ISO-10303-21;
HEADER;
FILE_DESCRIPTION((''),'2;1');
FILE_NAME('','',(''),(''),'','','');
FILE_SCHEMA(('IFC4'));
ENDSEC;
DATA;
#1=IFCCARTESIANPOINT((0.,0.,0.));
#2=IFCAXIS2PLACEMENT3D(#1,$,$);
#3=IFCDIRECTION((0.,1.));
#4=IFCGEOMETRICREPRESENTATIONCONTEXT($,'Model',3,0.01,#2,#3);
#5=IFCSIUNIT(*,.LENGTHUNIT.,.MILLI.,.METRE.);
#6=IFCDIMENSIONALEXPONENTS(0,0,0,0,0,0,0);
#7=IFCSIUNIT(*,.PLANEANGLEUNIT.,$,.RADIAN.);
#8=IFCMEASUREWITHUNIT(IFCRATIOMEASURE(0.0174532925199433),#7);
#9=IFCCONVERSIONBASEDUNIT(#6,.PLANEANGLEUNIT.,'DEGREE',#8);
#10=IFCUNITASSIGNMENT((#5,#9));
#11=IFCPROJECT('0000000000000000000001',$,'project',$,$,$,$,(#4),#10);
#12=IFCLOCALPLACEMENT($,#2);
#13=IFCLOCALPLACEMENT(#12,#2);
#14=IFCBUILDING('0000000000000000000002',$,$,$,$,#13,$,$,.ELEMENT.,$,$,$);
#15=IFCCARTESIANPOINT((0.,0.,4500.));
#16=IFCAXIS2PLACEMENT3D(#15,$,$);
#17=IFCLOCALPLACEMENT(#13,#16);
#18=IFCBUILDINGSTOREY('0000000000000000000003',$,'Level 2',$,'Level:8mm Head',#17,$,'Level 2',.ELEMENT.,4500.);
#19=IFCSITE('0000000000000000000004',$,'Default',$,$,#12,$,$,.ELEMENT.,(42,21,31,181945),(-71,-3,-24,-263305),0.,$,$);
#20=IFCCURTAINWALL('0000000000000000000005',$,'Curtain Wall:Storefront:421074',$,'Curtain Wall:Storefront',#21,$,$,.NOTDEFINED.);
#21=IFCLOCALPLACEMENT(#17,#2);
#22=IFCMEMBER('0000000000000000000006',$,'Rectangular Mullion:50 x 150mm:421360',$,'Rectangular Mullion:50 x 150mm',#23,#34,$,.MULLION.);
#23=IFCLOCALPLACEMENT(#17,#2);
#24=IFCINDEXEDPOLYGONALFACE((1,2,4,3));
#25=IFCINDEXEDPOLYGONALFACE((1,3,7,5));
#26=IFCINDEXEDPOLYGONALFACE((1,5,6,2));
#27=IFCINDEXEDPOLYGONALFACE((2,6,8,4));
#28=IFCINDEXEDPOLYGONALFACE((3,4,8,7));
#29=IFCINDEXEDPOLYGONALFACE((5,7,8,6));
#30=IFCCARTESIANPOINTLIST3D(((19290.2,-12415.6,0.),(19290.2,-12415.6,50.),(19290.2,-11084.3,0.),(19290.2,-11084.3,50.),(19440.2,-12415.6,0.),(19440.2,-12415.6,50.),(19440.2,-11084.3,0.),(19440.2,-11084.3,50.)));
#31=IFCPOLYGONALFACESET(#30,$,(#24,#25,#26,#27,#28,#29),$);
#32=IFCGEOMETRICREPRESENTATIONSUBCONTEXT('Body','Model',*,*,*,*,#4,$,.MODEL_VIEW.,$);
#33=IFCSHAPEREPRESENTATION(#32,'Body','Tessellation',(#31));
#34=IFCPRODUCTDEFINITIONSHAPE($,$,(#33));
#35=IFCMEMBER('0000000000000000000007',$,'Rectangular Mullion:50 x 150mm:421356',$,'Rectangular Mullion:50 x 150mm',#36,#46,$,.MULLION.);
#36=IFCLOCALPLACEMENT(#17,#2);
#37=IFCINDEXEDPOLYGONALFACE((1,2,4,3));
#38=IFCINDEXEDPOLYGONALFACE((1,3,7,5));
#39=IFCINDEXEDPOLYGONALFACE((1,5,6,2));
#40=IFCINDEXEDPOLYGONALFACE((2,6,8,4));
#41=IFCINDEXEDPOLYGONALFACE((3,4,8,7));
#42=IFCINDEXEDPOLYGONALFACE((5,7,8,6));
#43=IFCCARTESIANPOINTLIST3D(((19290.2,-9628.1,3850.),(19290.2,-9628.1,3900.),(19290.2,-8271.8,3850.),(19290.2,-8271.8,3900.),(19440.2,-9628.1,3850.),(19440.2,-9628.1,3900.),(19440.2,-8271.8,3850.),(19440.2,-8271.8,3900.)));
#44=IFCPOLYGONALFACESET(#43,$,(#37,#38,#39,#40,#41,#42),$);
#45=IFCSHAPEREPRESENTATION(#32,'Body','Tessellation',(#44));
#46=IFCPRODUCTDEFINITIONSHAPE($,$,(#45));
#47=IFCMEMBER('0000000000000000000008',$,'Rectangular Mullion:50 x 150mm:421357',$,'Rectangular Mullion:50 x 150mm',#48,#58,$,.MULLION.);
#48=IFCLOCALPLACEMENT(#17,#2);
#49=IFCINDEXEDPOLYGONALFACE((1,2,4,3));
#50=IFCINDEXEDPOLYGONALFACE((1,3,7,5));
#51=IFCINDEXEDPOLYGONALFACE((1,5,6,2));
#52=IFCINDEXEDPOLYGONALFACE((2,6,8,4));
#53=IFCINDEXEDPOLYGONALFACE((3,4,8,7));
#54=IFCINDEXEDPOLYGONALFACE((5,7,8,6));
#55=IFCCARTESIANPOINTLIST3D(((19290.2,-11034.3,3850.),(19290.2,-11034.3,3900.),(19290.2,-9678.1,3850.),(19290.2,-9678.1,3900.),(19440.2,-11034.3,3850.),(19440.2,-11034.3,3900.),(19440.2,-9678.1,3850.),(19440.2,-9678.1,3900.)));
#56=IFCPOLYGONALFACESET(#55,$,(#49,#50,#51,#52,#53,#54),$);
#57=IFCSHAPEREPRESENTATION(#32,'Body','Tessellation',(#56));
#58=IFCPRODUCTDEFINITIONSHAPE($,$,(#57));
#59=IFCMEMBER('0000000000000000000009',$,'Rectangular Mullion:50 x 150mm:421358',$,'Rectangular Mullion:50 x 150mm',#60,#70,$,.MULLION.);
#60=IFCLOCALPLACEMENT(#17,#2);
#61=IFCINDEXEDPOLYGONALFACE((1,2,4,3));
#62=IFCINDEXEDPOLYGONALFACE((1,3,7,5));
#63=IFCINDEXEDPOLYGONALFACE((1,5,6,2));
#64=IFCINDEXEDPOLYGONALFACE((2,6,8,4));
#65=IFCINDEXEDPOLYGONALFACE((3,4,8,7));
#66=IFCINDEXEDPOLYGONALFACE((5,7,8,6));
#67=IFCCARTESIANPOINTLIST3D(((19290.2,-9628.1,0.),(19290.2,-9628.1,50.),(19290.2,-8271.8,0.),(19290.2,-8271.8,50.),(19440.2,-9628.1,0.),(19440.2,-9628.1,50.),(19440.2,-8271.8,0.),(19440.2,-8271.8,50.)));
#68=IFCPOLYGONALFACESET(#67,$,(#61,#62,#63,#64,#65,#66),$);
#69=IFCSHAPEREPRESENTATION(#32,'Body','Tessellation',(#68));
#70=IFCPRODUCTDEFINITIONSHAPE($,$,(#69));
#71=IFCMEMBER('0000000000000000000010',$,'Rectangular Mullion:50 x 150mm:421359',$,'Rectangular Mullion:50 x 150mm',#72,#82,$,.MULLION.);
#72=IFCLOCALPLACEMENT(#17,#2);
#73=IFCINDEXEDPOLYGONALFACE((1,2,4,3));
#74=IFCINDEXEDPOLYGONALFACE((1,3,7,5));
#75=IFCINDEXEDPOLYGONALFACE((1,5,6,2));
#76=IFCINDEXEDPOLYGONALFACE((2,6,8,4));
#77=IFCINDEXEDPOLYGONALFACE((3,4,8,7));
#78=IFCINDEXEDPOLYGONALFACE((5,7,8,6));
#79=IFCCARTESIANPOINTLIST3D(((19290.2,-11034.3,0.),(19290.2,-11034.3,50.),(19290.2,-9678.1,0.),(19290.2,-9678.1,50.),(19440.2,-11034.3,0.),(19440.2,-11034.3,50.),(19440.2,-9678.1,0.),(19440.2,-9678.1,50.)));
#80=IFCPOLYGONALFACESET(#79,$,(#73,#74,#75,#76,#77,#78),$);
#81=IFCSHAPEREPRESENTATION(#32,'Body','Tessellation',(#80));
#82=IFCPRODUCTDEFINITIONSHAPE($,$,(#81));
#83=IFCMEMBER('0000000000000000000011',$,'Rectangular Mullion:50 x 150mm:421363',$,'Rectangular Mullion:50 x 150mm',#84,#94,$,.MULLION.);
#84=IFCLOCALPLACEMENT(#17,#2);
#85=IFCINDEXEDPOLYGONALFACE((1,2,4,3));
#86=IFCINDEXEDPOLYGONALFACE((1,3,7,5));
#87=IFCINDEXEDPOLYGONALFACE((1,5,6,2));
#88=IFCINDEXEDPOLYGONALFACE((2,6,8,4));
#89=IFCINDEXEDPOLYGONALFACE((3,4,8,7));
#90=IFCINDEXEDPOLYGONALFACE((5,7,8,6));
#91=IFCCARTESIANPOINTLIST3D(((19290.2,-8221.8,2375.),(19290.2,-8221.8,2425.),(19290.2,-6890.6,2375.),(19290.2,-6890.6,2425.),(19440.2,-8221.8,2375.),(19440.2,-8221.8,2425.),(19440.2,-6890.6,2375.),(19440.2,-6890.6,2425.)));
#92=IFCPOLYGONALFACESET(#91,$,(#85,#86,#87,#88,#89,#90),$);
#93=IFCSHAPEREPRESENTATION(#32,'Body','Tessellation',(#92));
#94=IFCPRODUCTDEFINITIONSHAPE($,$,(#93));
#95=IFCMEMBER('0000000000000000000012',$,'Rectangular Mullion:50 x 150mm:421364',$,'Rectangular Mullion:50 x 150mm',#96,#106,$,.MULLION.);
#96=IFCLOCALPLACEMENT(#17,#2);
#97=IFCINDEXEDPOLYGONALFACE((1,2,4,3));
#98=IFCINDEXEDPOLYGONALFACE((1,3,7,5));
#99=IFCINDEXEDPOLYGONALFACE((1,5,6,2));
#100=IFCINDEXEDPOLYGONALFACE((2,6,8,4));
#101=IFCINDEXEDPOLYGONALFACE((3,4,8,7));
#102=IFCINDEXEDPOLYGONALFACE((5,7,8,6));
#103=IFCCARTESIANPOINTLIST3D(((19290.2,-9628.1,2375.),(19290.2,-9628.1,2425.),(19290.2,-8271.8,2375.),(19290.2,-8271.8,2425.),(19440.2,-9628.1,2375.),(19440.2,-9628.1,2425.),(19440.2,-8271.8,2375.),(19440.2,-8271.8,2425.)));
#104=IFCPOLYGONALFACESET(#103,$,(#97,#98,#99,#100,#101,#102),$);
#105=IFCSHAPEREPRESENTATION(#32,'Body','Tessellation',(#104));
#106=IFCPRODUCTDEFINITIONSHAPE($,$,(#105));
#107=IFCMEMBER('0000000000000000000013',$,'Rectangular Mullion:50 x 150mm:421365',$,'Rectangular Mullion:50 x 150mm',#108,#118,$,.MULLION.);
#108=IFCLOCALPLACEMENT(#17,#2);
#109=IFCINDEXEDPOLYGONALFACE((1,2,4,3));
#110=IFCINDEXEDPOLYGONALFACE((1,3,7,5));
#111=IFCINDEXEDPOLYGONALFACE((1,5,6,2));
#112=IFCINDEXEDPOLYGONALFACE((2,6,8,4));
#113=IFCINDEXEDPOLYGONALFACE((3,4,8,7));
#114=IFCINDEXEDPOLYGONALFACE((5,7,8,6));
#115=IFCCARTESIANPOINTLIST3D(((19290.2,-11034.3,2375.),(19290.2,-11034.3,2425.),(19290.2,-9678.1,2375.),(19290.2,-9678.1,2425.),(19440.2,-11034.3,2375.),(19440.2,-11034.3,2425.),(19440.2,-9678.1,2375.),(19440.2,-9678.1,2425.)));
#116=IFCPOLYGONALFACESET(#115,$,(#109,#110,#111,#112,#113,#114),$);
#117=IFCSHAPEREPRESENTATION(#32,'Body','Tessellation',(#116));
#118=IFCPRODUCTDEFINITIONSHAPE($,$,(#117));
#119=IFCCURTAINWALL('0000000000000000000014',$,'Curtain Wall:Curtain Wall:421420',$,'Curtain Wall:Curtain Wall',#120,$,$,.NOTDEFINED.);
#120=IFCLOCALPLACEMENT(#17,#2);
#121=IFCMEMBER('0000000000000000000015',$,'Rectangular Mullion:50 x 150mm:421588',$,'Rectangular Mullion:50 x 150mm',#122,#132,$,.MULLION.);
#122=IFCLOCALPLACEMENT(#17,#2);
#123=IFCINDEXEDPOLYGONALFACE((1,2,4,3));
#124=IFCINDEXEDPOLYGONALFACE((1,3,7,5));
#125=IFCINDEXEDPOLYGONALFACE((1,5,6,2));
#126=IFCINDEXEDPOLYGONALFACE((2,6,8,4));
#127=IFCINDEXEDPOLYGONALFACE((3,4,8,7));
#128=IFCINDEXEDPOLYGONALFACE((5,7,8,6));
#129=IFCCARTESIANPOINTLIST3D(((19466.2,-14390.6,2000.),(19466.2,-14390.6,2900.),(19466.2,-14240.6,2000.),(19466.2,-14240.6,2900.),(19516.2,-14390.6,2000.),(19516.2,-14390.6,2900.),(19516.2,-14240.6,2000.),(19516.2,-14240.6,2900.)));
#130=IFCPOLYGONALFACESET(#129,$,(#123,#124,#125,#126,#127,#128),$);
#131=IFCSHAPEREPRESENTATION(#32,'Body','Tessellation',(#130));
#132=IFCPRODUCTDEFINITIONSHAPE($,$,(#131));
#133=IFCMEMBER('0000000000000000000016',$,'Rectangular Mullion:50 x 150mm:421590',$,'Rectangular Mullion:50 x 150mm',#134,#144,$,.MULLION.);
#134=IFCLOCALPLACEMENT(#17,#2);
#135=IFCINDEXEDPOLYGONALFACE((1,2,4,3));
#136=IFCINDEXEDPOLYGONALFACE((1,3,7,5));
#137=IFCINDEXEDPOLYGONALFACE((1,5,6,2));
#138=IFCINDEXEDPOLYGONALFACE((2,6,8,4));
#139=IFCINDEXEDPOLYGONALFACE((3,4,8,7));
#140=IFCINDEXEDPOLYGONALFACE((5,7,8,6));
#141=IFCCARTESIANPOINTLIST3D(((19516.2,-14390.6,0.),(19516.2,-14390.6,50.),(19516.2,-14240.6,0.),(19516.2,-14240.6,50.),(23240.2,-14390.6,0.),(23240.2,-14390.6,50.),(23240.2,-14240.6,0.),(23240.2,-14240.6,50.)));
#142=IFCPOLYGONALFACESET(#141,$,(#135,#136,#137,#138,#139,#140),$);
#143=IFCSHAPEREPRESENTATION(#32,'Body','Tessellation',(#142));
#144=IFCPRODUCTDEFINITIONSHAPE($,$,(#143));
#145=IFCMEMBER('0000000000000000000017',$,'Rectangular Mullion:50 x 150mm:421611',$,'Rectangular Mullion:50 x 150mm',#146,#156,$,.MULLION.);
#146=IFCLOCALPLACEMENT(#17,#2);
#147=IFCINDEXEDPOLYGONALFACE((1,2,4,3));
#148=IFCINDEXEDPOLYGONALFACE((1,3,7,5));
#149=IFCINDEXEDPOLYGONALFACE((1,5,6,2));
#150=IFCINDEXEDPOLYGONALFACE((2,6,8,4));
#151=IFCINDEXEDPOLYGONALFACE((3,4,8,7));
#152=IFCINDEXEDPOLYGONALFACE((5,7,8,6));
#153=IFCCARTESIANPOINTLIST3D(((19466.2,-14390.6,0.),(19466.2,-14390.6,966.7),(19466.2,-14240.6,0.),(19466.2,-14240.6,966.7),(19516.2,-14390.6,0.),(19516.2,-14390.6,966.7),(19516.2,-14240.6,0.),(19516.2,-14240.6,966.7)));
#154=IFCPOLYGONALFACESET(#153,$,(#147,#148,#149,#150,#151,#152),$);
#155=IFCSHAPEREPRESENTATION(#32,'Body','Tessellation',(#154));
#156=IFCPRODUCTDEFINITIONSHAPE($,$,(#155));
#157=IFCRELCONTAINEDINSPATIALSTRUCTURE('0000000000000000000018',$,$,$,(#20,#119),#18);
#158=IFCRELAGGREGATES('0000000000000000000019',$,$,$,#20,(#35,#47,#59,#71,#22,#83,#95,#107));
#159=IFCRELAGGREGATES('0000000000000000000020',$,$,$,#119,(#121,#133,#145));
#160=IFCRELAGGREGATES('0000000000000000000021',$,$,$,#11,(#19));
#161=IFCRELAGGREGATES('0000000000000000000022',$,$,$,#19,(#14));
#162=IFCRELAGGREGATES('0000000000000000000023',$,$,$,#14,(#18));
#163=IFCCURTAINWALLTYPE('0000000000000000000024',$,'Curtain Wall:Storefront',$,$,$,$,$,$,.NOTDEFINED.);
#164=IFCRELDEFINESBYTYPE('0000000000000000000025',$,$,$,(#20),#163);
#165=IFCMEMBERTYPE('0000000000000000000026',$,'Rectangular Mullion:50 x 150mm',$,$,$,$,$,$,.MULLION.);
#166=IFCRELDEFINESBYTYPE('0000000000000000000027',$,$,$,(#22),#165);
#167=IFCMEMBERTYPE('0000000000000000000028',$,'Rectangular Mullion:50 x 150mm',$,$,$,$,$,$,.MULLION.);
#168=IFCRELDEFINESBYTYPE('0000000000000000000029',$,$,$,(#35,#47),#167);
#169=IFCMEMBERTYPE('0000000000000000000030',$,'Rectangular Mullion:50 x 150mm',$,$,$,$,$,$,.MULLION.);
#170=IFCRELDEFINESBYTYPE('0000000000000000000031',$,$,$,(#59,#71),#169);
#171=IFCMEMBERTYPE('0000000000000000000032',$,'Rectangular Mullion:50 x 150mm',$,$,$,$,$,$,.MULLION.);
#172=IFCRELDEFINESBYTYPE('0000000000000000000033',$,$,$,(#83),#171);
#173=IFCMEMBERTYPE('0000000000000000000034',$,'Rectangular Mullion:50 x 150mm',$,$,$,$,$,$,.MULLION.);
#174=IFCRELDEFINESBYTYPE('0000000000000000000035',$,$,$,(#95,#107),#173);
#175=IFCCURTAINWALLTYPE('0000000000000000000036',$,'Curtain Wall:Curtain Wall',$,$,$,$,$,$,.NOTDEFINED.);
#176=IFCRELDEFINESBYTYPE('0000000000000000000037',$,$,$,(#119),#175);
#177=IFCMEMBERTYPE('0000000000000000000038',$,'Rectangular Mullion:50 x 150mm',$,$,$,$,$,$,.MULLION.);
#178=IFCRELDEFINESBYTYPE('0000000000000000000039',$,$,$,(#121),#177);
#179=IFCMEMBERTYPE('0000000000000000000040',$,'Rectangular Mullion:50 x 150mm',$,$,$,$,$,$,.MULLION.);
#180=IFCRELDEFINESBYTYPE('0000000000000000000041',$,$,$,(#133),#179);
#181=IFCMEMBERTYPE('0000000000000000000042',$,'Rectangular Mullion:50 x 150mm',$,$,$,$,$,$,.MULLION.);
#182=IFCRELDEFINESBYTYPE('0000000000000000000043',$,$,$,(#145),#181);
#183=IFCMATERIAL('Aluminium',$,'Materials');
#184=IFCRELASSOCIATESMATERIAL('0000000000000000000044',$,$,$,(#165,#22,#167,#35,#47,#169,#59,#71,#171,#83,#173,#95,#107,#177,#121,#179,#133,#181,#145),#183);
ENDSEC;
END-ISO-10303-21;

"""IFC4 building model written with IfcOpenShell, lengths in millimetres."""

from ifc_helpers import new_model, entity, si_unit, converted_unit, direction, frame, origin, place, context, subcontext, project, spatial, indexed_curve, outline, extrude, source, transform, mapped, material, type_object, type_shapes, element, aggregate, save


model = new_model("IFC4")

# Units and contexts
model_context = context("Model", 3, precision=0.01, world=origin(), true_north=direction((0.0, 1.0)))
body_context = subcontext(model_context, "Body", "Model", "MODEL_VIEW")
ifc_project = project(units=[si_unit("LENGTHUNIT", "METRE", prefix="MILLI"), converted_unit("PLANEANGLEUNIT", "DEGREE", entity("IfcRatioMeasure", 0.0174532925199433), si_unit("PLANEANGLEUNIT", "RADIAN"), dimensions=[0, 0, 0, 0, 0, 0, 0])], contexts=[model_context])

# Site, building, storey
site_placement = place(None, origin())
site = spatial("IfcSite", under=ifc_project, at=site_placement, Name="Default", CompositionType="ELEMENT", RefLatitude=(42, 21, 31, 181945), RefLongitude=(-71, -3, -24, -263305), RefElevation=0.0)
building_placement = place(site_placement, origin())
building = spatial("IfcBuilding", under=site, at=building_placement, CompositionType="ELEMENT")
storey_placement = place(building_placement, frame((0.0, 0.0, 4500.0)))
storey = spatial("IfcBuildingStorey", under=building, at=storey_placement, Name="Level 2", ObjectType="Level:8mm Head", LongName="Level 2", CompositionType="ELEMENT", Elevation=4500.0)

# Curtain wall
curtain_wall_type_1 = type_object("IfcCurtainWallType", Name="Curtain Wall:Storefront", PredefinedType="NOTDEFINED")
curtain_wall_1_placement = place(storey_placement, frame((0.0, 0.0, -4500.0)))
curtain_wall_1 = element("IfcCurtainWall", 1, at=curtain_wall_1_placement, inside=storey, type_object=curtain_wall_type_1, Name="Curtain Wall:Storefront:421074", ObjectType="Curtain Wall:Storefront", PredefinedType="NOTDEFINED")
ifc_material_1 = material(Name="Aluminium", Category="Materials")

# Members
member_type_1 = type_object("IfcMemberType", Name="Rectangular Mullion:50 x 150mm", PredefinedType="MULLION", material=ifc_material_1)
shared_shape_1 = source(origin(), body_context, "Body", "SweptSolid", [
    extrude(outline(indexed_curve([(-75.0, -25.0), (75.0, -25.0), (75.0, 25.0), (-75.0, 25.0), (-75.0, -25.0)], self_intersect=False)), frame((-25.0, 0.0, -1331.3), z_axis=(0.0, 0.0, 1.0), x_axis=(0.0, -1.0, 0.0)), (0.0, 0.0, 1.0), 1331.3),
])
type_shapes(member_type_1, [shared_shape_1])
member_1_placement = place(storey_placement, frame((19365.2, -11084.3, 0.0), z_axis=(0.0, 1.0, 0.0), x_axis=(0.0, 0.0, -1.0)))
member_1 = element("IfcMember", 2, at=member_1_placement, type_object=member_type_1, material=ifc_material_1, Name="Rectangular Mullion:50 x 150mm:421360", ObjectType="Rectangular Mullion:50 x 150mm", PredefinedType="MULLION", context=body_context, shape_type="MappedRepresentation", body=[
    mapped(shared_shape_1, transform((0.0, 0.0, 0.0), scale=1.0)),
])
member_type_2 = type_object("IfcMemberType", Name="Rectangular Mullion:50 x 150mm", PredefinedType="MULLION", material=ifc_material_1)
shared_shape_2 = source(origin(), body_context, "Body", "SweptSolid", [
    extrude(outline(indexed_curve([(-75.0, -25.0), (75.0, -25.0), (75.0, 25.0), (-75.0, 25.0), (-75.0, -25.0)], self_intersect=False)), frame((-25.0, 0.0, -1356.2), z_axis=(0.0, 0.0, 1.0), x_axis=(0.0, -1.0, 0.0)), (0.0, 0.0, 1.0), 1356.2),
])
type_shapes(member_type_2, [shared_shape_2])
member_2_placement = place(storey_placement, frame((19365.2, -9628.1, 3900.0), z_axis=(0.0, -1.0, 0.0), x_axis=(0.0, 0.0, 1.0)))
member_2 = element("IfcMember", 3, at=member_2_placement, type_object=member_type_2, material=ifc_material_1, Name="Rectangular Mullion:50 x 150mm:421356", ObjectType="Rectangular Mullion:50 x 150mm", PredefinedType="MULLION", context=body_context, shape_type="MappedRepresentation", body=[
    mapped(shared_shape_2, transform((0.0, 0.0, 0.0), scale=1.0)),
])
member_3_placement = place(storey_placement, frame((19365.2, -11034.3, 3900.0), z_axis=(0.0, -1.0, 0.0), x_axis=(0.0, 0.0, 1.0)))
member_3 = element("IfcMember", 4, at=member_3_placement, type_object=member_type_2, material=ifc_material_1, Name="Rectangular Mullion:50 x 150mm:421357", ObjectType="Rectangular Mullion:50 x 150mm", PredefinedType="MULLION", context=body_context, shape_type="MappedRepresentation", body=[
    mapped(shared_shape_2, transform((0.0, 0.0, 0.0), scale=1.0)),
])
member_type_3 = type_object("IfcMemberType", Name="Rectangular Mullion:50 x 150mm", PredefinedType="MULLION", material=ifc_material_1)
shared_shape_3 = source(origin(), body_context, "Body", "SweptSolid", [
    extrude(outline(indexed_curve([(-75.0, -25.0), (75.0, -25.0), (75.0, 25.0), (-75.0, 25.0), (-75.0, -25.0)], self_intersect=False)), frame((-25.0, 0.0, -1356.2), z_axis=(0.0, 0.0, 1.0), x_axis=(0.0, -1.0, 0.0)), (0.0, 0.0, 1.0), 1356.2),
])
type_shapes(member_type_3, [shared_shape_3])
member_4_placement = place(storey_placement, frame((19365.2, -8271.8, 0.0), z_axis=(0.0, 1.0, 0.0), x_axis=(0.0, 0.0, -1.0)))
member_4 = element("IfcMember", 5, at=member_4_placement, type_object=member_type_3, material=ifc_material_1, Name="Rectangular Mullion:50 x 150mm:421358", ObjectType="Rectangular Mullion:50 x 150mm", PredefinedType="MULLION", context=body_context, shape_type="MappedRepresentation", body=[
    mapped(shared_shape_3, transform((0.0, 0.0, 0.0), scale=1.0)),
])
member_5_placement = place(storey_placement, frame((19365.2, -9678.1, 0.0), z_axis=(0.0, 1.0, 0.0), x_axis=(0.0, 0.0, -1.0)))
member_5 = element("IfcMember", 6, at=member_5_placement, type_object=member_type_3, material=ifc_material_1, Name="Rectangular Mullion:50 x 150mm:421359", ObjectType="Rectangular Mullion:50 x 150mm", PredefinedType="MULLION", context=body_context, shape_type="MappedRepresentation", body=[
    mapped(shared_shape_3, transform((0.0, 0.0, 0.0), scale=1.0)),
])
member_type_4 = type_object("IfcMemberType", Name="Rectangular Mullion:50 x 150mm", PredefinedType="MULLION", material=ifc_material_1)
shared_shape_4 = source(origin(), body_context, "Body", "SweptSolid", [
    extrude(outline(indexed_curve([(-75.0, -25.0), (75.0, -25.0), (75.0, 25.0), (-75.0, 25.0), (-75.0, -25.0)], self_intersect=False)), frame((0.0, 0.0, -1331.3), z_axis=(0.0, 0.0, 1.0), x_axis=(0.0, -1.0, 0.0)), (0.0, 0.0, 1.0), 1331.3),
])
type_shapes(member_type_4, [shared_shape_4])
member_6_placement = place(storey_placement, frame((19365.2, -8221.8, 2400.0), z_axis=(0.0, -1.0, 0.0), x_axis=(0.0, 0.0, 1.0)))
member_6 = element("IfcMember", 7, at=member_6_placement, type_object=member_type_4, material=ifc_material_1, Name="Rectangular Mullion:50 x 150mm:421363", ObjectType="Rectangular Mullion:50 x 150mm", PredefinedType="MULLION", context=body_context, shape_type="MappedRepresentation", body=[
    mapped(shared_shape_4, transform((0.0, 0.0, 0.0), scale=1.0)),
])
member_type_5 = type_object("IfcMemberType", Name="Rectangular Mullion:50 x 150mm", PredefinedType="MULLION", material=ifc_material_1)
shared_shape_5 = source(origin(), body_context, "Body", "SweptSolid", [
    extrude(outline(indexed_curve([(-75.0, -25.0), (75.0, -25.0), (75.0, 25.0), (-75.0, 25.0), (-75.0, -25.0)], self_intersect=False)), frame((0.0, 0.0, -1356.2), z_axis=(0.0, 0.0, 1.0), x_axis=(0.0, -1.0, 0.0)), (0.0, 0.0, 1.0), 1356.2),
])
type_shapes(member_type_5, [shared_shape_5])
member_7_placement = place(storey_placement, frame((19365.2, -9628.1, 2400.0), z_axis=(0.0, -1.0, 0.0), x_axis=(0.0, 0.0, 1.0)))
member_7 = element("IfcMember", 8, at=member_7_placement, type_object=member_type_5, material=ifc_material_1, Name="Rectangular Mullion:50 x 150mm:421364", ObjectType="Rectangular Mullion:50 x 150mm", PredefinedType="MULLION", context=body_context, shape_type="MappedRepresentation", body=[
    mapped(shared_shape_5, transform((0.0, 0.0, 0.0), scale=1.0)),
])
member_8_placement = place(storey_placement, frame((19365.2, -11034.3, 2400.0), z_axis=(0.0, -1.0, 0.0), x_axis=(0.0, 0.0, 1.0)))
member_8 = element("IfcMember", 9, at=member_8_placement, type_object=member_type_5, material=ifc_material_1, Name="Rectangular Mullion:50 x 150mm:421365", ObjectType="Rectangular Mullion:50 x 150mm", PredefinedType="MULLION", context=body_context, shape_type="MappedRepresentation", body=[
    mapped(shared_shape_5, transform((0.0, 0.0, 0.0), scale=1.0)),
])

# Curtain wall, members
curtain_wall_type_2 = type_object("IfcCurtainWallType", Name="Curtain Wall:Curtain Wall", PredefinedType="NOTDEFINED")
curtain_wall_2_placement = place(storey_placement, frame((0.0, 0.0, -4500.0)))
curtain_wall_2 = element("IfcCurtainWall", 10, at=curtain_wall_2_placement, inside=storey, type_object=curtain_wall_type_2, Name="Curtain Wall:Curtain Wall:421420", ObjectType="Curtain Wall:Curtain Wall", PredefinedType="NOTDEFINED")
member_type_6 = type_object("IfcMemberType", Name="Rectangular Mullion:50 x 150mm", PredefinedType="MULLION", material=ifc_material_1)
shared_shape_6 = source(origin(), body_context, "Body", "SweptSolid", [
    extrude(outline(indexed_curve([(-75.0, -25.0), (75.0, -25.0), (75.0, 25.0), (-75.0, 25.0), (-75.0, -25.0)], self_intersect=False)), frame((-25.0, 0.0, -900.0), z_axis=(0.0, 0.0, 1.0), x_axis=(0.0, -1.0, 0.0)), (0.0, 0.0, 1.0), 900.0),
])
type_shapes(member_type_6, [shared_shape_6])
member_9_placement = place(storey_placement, frame((19466.2, -14315.6, 2900.0), z_axis=(0.0, 0.0, 1.0), x_axis=(-1.0, 0.0, 0.0)))
member_9 = element("IfcMember", 11, at=member_9_placement, type_object=member_type_6, material=ifc_material_1, Name="Rectangular Mullion:50 x 150mm:421588", ObjectType="Rectangular Mullion:50 x 150mm", PredefinedType="MULLION", context=body_context, shape_type="MappedRepresentation", body=[
    mapped(shared_shape_6, transform((0.0, 0.0, 0.0), scale=1.0)),
])
member_type_7 = type_object("IfcMemberType", Name="Rectangular Mullion:50 x 150mm", PredefinedType="MULLION", material=ifc_material_1)
shared_shape_7 = source(origin(), body_context, "Body", "SweptSolid", [
    extrude(outline(indexed_curve([(-75.0, -25.0), (75.0, -25.0), (75.0, 25.0), (-75.0, 25.0), (-75.0, -25.0)], self_intersect=False)), frame((-25.0, 0.0, -3724.0), z_axis=(0.0, 0.0, 1.0), x_axis=(0.0, -1.0, 0.0)), (0.0, 0.0, 1.0), 3724.0),
])
type_shapes(member_type_7, [shared_shape_7])
member_10_placement = place(storey_placement, frame((19516.2, -14315.6, 0.0), z_axis=(-1.0, 0.0, 0.0), x_axis=(0.0, 0.0, -1.0)))
member_10 = element("IfcMember", 12, at=member_10_placement, type_object=member_type_7, material=ifc_material_1, Name="Rectangular Mullion:50 x 150mm:421590", ObjectType="Rectangular Mullion:50 x 150mm", PredefinedType="MULLION", context=body_context, shape_type="MappedRepresentation", body=[
    mapped(shared_shape_7, transform((0.0, 0.0, 0.0), scale=1.0)),
])
member_type_8 = type_object("IfcMemberType", Name="Rectangular Mullion:50 x 150mm", PredefinedType="MULLION", material=ifc_material_1)
shared_shape_8 = source(origin(), body_context, "Body", "SweptSolid", [
    extrude(outline(indexed_curve([(-75.0, -25.0), (75.0, -25.0), (75.0, 25.0), (-75.0, 25.0), (-75.0, -25.0)], self_intersect=False)), frame((-25.0, 0.0, -966.7), z_axis=(0.0, 0.0, 1.0), x_axis=(0.0, -1.0, 0.0)), (0.0, 0.0, 1.0), 966.7),
])
type_shapes(member_type_8, [shared_shape_8])
member_11_placement = place(storey_placement, frame((19466.2, -14315.6, 966.7), z_axis=(0.0, 0.0, 1.0), x_axis=(-1.0, 0.0, 0.0)))
member_11 = element("IfcMember", 13, at=member_11_placement, type_object=member_type_8, material=ifc_material_1, Name="Rectangular Mullion:50 x 150mm:421611", ObjectType="Rectangular Mullion:50 x 150mm", PredefinedType="MULLION", context=body_context, shape_type="MappedRepresentation", body=[
    mapped(shared_shape_8, transform((0.0, 0.0, 0.0), scale=1.0)),
])

aggregate(curtain_wall_1, [member_2, member_3, member_4, member_5, member_1, member_6, member_7, member_8])

aggregate(curtain_wall_2, [member_9, member_10, member_11])

save(model, "model.ifc")
